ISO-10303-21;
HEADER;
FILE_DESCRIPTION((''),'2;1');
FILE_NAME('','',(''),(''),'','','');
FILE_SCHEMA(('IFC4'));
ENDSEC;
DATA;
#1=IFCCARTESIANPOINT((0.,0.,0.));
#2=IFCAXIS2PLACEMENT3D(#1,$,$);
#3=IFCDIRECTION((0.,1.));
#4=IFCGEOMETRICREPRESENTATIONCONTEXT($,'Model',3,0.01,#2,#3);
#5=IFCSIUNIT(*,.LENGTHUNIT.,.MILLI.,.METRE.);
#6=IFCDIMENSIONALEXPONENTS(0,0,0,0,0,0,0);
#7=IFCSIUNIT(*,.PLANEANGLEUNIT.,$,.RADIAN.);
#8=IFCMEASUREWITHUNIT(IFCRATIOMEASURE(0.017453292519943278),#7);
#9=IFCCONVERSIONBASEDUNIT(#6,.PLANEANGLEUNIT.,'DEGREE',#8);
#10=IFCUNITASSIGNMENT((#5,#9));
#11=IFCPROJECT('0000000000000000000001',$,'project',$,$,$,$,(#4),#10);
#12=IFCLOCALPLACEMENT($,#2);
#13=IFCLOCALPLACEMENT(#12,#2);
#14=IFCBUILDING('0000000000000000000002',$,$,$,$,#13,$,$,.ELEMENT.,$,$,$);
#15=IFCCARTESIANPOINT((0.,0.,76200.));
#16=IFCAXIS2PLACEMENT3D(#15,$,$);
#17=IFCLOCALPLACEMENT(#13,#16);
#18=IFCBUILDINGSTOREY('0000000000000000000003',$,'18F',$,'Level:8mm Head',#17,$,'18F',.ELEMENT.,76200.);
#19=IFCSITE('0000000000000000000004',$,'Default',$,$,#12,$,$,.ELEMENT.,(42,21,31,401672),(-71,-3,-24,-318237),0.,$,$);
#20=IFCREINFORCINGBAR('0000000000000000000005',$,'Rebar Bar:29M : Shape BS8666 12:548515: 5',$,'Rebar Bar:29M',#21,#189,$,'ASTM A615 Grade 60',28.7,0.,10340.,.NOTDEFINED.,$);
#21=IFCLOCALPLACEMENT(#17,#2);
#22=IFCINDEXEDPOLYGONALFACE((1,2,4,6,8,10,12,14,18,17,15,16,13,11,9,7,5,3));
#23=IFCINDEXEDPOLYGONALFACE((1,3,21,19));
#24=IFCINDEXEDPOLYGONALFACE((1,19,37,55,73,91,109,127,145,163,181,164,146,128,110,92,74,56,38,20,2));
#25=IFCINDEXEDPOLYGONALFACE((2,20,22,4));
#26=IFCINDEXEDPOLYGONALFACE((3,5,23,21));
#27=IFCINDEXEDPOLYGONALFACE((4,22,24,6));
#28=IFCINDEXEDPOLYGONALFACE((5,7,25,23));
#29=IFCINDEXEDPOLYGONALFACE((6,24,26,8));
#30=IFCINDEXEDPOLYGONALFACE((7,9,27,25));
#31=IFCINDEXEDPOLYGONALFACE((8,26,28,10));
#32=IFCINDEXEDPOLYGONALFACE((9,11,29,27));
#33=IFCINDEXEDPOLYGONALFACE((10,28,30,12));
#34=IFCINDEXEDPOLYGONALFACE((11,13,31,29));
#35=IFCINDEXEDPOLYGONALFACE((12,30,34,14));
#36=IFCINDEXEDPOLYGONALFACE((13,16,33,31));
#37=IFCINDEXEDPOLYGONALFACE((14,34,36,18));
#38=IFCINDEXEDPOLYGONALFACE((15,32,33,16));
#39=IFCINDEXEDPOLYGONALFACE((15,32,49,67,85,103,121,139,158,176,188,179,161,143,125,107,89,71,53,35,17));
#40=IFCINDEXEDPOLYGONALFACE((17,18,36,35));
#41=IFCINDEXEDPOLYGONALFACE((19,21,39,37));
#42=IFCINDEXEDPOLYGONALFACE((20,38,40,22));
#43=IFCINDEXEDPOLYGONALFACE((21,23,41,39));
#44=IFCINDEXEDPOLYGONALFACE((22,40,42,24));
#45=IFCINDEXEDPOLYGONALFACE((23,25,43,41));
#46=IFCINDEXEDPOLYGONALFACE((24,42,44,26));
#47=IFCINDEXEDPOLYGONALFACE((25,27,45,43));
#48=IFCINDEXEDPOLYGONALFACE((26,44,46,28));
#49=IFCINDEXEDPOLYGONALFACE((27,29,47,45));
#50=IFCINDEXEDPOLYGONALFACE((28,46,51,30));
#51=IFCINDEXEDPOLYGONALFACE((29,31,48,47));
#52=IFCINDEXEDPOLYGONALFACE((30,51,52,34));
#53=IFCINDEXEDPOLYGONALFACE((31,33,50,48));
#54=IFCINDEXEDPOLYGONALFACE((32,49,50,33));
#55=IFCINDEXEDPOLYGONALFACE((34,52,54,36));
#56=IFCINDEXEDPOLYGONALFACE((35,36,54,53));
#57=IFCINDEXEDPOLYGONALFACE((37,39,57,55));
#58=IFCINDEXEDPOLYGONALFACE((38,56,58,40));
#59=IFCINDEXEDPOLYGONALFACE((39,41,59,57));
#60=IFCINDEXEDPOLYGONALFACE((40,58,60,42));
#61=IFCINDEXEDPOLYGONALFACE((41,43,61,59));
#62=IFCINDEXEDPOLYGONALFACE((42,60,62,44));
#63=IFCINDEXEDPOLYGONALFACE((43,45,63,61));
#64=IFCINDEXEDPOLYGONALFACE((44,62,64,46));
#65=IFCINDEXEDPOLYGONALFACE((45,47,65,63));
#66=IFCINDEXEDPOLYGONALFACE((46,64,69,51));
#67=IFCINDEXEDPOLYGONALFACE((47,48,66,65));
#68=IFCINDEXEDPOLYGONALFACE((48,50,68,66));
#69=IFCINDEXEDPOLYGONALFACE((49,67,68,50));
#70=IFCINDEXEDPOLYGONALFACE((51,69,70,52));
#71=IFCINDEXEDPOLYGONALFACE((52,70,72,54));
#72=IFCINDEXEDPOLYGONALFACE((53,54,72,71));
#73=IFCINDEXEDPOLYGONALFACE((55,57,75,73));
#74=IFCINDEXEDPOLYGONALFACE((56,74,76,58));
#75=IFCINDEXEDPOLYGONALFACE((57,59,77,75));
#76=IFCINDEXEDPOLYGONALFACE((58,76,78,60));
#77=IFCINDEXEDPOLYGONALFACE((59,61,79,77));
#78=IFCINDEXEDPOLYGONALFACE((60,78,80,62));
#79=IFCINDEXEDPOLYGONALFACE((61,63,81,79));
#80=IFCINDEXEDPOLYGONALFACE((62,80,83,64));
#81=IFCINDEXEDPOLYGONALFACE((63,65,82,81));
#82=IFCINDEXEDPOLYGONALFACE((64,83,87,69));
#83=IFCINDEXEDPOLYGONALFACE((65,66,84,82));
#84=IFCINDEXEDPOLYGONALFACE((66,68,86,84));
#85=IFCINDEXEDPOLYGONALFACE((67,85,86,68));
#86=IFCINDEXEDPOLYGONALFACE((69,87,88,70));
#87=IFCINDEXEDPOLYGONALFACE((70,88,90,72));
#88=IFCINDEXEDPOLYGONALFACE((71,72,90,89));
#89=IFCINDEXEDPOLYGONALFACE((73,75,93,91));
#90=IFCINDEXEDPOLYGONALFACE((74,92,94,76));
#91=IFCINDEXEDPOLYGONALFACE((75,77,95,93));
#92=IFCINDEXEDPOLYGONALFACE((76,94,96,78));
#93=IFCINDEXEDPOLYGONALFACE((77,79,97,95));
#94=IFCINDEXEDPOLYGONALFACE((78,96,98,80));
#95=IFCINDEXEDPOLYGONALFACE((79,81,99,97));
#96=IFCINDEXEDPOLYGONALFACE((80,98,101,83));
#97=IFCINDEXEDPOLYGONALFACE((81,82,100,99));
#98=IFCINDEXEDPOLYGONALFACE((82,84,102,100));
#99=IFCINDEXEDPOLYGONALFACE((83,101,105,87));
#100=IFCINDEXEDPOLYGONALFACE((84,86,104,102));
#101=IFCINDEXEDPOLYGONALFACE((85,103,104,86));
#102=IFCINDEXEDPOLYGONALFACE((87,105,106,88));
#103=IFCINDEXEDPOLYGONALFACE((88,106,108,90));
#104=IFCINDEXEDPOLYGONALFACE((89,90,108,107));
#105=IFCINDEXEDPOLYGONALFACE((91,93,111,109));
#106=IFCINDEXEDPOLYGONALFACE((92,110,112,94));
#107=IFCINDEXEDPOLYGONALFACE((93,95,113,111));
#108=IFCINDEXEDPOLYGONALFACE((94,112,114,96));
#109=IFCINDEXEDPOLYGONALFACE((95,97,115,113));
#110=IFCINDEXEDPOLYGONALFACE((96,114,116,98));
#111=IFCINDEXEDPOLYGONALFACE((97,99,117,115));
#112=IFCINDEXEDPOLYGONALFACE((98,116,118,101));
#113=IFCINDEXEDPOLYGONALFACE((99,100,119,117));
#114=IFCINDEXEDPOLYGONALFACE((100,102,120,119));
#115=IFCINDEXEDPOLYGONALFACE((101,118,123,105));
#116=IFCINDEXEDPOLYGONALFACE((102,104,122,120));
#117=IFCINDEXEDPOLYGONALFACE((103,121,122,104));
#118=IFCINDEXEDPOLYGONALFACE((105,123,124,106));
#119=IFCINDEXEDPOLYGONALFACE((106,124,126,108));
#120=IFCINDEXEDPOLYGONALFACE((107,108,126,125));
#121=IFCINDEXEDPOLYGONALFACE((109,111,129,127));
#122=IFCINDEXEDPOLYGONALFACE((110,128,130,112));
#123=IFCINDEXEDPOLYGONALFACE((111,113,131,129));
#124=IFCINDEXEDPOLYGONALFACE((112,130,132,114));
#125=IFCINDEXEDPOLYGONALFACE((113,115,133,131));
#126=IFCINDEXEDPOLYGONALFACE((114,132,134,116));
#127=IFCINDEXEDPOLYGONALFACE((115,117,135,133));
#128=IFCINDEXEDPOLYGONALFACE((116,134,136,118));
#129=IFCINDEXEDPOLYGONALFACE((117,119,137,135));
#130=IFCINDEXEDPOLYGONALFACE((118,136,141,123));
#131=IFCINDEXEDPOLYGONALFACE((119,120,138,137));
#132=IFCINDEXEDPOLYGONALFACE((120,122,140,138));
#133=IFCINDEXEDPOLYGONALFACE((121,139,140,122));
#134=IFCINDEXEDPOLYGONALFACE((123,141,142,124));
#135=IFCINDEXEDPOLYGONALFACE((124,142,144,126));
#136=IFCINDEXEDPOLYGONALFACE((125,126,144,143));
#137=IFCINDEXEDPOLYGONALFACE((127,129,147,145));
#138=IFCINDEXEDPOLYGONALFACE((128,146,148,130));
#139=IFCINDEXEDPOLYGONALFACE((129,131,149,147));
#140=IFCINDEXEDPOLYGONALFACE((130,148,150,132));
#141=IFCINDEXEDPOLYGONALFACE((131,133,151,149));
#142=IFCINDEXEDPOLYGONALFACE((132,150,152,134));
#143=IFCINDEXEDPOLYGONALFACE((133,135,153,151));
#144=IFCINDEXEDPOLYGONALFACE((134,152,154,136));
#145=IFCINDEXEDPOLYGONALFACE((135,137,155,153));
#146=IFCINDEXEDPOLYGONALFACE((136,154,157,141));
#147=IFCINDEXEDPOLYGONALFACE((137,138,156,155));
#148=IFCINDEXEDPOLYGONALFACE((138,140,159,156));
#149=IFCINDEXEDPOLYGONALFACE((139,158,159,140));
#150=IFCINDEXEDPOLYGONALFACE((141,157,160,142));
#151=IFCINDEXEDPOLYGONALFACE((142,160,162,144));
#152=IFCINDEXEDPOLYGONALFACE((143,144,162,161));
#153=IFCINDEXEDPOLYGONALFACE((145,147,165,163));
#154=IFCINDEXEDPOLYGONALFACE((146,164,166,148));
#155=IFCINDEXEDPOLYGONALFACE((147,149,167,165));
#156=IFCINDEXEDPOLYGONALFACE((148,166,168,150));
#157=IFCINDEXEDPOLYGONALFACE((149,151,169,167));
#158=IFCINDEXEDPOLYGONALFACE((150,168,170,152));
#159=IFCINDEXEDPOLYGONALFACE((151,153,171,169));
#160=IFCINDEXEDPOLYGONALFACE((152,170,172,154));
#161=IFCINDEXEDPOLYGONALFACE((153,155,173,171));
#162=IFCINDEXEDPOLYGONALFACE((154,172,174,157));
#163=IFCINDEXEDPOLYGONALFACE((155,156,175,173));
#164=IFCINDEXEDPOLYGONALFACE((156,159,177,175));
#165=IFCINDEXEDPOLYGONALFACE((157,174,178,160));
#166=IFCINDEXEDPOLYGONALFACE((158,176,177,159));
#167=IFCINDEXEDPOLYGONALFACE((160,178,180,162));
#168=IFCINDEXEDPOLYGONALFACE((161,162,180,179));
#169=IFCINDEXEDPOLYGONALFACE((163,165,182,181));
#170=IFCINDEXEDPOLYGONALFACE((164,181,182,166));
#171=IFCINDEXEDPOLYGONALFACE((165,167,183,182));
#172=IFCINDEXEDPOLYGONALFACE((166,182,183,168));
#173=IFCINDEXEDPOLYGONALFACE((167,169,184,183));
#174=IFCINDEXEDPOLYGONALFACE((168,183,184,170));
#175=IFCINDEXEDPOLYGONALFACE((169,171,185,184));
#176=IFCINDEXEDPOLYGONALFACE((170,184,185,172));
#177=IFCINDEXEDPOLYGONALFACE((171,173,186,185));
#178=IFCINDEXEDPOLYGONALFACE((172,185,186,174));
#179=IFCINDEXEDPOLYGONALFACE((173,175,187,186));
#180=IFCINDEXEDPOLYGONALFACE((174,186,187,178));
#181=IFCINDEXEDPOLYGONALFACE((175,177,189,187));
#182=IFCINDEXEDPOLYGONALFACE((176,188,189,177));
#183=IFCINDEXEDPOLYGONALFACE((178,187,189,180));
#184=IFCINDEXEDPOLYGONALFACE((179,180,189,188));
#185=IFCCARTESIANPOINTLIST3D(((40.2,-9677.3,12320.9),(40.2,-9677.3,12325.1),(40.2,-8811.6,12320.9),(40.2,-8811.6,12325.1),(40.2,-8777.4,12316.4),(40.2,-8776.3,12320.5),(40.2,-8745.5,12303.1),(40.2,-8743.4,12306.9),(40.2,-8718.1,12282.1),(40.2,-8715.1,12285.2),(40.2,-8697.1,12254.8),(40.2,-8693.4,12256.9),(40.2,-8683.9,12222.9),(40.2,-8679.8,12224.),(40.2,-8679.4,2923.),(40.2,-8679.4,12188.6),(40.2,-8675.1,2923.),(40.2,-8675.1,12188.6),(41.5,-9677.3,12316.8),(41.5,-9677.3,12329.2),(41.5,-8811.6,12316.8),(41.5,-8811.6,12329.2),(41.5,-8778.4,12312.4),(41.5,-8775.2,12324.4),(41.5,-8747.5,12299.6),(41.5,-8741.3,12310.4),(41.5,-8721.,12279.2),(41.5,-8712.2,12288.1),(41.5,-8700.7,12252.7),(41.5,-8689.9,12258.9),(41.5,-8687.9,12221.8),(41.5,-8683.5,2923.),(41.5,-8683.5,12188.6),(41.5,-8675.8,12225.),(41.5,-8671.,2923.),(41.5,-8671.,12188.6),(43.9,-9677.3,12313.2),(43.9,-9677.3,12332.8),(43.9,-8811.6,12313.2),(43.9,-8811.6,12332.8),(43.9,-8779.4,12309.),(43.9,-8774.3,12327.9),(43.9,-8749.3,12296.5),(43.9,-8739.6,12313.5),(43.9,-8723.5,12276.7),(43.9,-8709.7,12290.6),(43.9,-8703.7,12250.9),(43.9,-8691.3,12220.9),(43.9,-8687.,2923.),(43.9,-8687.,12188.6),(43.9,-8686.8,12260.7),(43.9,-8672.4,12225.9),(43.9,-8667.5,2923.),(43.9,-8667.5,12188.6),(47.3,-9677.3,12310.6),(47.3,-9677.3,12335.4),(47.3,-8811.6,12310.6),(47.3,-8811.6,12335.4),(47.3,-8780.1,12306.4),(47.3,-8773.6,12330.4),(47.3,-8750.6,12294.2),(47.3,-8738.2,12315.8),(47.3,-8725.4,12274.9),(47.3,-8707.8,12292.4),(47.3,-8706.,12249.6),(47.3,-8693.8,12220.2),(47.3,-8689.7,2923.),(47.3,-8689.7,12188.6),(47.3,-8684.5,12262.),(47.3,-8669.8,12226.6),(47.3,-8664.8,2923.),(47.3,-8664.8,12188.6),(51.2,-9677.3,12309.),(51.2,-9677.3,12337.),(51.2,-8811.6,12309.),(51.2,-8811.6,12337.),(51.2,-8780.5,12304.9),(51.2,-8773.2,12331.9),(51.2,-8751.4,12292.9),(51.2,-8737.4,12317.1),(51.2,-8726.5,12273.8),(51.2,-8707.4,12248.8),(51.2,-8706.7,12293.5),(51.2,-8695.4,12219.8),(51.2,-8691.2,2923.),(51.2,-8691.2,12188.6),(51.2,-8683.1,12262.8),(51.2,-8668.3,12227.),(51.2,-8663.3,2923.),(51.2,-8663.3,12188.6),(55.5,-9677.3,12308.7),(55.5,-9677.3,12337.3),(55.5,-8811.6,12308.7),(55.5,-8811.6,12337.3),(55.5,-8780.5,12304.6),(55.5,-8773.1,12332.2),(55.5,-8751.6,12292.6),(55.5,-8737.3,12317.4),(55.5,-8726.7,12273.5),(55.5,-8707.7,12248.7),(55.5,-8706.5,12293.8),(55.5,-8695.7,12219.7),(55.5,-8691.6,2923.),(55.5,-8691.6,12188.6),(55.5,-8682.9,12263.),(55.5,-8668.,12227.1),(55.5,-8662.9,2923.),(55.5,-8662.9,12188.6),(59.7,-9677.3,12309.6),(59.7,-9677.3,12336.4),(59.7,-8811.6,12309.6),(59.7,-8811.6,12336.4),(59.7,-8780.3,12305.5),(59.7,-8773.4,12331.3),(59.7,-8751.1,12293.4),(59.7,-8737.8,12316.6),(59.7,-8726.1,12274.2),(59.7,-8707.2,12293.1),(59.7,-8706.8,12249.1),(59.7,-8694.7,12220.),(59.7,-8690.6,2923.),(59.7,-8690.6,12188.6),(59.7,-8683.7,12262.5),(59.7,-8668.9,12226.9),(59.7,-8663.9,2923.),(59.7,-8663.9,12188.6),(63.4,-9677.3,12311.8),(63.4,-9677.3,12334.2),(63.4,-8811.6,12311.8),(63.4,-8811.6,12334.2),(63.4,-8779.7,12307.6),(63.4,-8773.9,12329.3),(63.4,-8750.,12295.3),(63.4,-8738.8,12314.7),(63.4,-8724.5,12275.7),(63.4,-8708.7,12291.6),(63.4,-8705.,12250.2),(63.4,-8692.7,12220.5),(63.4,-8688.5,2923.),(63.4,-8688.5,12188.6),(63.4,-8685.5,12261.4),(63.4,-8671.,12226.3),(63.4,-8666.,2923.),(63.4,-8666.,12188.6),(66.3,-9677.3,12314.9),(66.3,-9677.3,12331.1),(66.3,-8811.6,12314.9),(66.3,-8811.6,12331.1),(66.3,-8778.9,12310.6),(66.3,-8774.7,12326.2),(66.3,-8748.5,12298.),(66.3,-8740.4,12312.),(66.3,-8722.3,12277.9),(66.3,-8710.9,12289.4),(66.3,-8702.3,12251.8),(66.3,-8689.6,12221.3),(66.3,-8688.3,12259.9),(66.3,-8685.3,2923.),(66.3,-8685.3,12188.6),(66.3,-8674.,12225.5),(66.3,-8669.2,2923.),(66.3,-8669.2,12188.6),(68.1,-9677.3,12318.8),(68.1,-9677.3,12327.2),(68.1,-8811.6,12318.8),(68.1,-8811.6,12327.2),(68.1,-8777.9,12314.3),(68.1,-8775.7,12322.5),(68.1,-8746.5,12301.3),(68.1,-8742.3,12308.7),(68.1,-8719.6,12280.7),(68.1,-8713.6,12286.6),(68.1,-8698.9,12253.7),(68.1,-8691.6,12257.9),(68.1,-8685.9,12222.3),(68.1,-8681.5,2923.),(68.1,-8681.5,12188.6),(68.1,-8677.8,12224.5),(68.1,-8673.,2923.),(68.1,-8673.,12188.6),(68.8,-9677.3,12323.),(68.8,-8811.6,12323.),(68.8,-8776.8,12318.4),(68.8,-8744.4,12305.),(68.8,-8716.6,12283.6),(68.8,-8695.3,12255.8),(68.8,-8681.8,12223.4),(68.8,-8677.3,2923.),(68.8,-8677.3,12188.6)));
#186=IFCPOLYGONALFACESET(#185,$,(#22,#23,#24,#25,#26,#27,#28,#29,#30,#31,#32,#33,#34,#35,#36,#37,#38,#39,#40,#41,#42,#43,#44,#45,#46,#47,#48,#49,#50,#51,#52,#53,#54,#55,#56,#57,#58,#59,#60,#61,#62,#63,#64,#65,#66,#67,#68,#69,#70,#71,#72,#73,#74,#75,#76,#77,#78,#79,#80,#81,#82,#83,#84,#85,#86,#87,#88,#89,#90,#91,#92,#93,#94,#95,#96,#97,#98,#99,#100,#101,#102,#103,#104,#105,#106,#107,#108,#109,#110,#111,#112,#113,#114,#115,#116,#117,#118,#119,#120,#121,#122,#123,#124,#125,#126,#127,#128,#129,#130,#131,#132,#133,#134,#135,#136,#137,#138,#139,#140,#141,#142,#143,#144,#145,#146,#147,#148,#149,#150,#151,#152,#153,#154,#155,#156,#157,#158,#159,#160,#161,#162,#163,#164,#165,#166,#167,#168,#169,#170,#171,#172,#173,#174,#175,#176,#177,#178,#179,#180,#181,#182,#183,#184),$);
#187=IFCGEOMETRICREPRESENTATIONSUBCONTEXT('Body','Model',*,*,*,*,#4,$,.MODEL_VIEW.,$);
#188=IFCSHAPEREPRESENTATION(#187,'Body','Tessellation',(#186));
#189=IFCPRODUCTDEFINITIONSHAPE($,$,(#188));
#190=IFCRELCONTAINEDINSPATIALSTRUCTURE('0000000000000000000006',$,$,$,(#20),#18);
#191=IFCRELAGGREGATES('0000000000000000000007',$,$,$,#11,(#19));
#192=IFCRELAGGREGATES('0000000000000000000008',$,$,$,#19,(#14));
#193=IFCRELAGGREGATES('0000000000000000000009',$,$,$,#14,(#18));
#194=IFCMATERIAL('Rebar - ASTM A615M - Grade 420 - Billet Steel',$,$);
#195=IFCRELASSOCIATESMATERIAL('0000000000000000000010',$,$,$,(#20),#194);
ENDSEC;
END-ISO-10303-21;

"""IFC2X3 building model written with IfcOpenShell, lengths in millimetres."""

from ifc_helpers import new_model, entity, si_unit, converted_unit, direction, frame, origin, place, context, subcontext, project, spatial, material, element, save


model = new_model("IFC2X3")

# Units and contexts
model_context = context("Model", 3, precision=0.01, world=origin(), true_north=direction((0.0, 1.0)))
body_context = subcontext(model_context, "Body", "Model", "MODEL_VIEW")
ifc_project = project(units=[si_unit("LENGTHUNIT", "METRE", prefix="MILLI"), converted_unit("PLANEANGLEUNIT", "DEGREE", entity("IfcRatioMeasure", 0.017453292519943278), si_unit("PLANEANGLEUNIT", "RADIAN"), dimensions=[0, 0, 0, 0, 0, 0, 0])], contexts=[model_context])

# Site, building, storey
site_placement = place(None, origin())
site = spatial("IfcSite", under=ifc_project, at=site_placement, Name="Default", CompositionType="ELEMENT", RefLatitude=(42, 21, 31, 401672), RefLongitude=(-71, -3, -24, -318237), RefElevation=0.0)
building_placement = place(site_placement, origin())
building = spatial("IfcBuilding", under=site, at=building_placement, CompositionType="ELEMENT")
storey_placement = place(building_placement, frame((0.0, 0.0, 76200.0)))
storey = spatial("IfcBuildingStorey", under=building, at=storey_placement, Name="18F", ObjectType="Level:8mm Head", LongName="18F", CompositionType="ELEMENT", Elevation=76200.0)

# Reinforcing bar
ifc_material_1 = material(Name="Rebar - ASTM A615M - Grade 420 - Billet Steel")
reinforcing_bar_1_placement = place(storey_placement, origin())
element("IfcReinforcingBar", 1, at=reinforcing_bar_1_placement, inside=storey, material=ifc_material_1, Name="Rebar Bar:29M : Shape BS8666 12:548515: 5", SteelGrade="ASTM A615 Grade 60", ObjectType="Rebar Bar:29M", BarLength=10340.0, BarRole="NOTDEFINED", CrossSectionArea=0.0, NominalDiameter=28.7, context=body_context, shape_type="AdvancedSweptSolid", body=[
    entity("IfcSweptDiskSolid", entity("IfcCompositeCurve", [entity("IfcCompositeCurveSegment", "CONTINUOUS", True, entity("IfcPolyline", [entity("IfcCartesianPoint", [54.4, -8677.3, 2923.0]), entity("IfcCartesianPoint", [54.4, -8677.3, 12188.6])])), entity("IfcCompositeCurveSegment", "CONTINUOUS", True, entity("IfcTrimmedCurve", entity("IfcCircle", entity("IfcAxis2Placement3D", entity("IfcCartesianPoint", [54.4, -8811.6, 12188.6]), entity("IfcDirection", [1.0, 0.0, 0.0]), entity("IfcDirection", [0.0, 0.0, 1.0])), 134.3), [entity("IfcParameterValue", 270.0)], [entity("IfcParameterValue", 360.0)], True, "PARAMETER")), entity("IfcCompositeCurveSegment", "CONTINUOUS", True, entity("IfcPolyline", [entity("IfcCartesianPoint", [54.4, -8811.6, 12323.0]), entity("IfcCartesianPoint", [54.4, -9677.3, 12323.0])]))], False), 14.3, None, 0.0, 92.0),
])

save(model, "model.ifc")
